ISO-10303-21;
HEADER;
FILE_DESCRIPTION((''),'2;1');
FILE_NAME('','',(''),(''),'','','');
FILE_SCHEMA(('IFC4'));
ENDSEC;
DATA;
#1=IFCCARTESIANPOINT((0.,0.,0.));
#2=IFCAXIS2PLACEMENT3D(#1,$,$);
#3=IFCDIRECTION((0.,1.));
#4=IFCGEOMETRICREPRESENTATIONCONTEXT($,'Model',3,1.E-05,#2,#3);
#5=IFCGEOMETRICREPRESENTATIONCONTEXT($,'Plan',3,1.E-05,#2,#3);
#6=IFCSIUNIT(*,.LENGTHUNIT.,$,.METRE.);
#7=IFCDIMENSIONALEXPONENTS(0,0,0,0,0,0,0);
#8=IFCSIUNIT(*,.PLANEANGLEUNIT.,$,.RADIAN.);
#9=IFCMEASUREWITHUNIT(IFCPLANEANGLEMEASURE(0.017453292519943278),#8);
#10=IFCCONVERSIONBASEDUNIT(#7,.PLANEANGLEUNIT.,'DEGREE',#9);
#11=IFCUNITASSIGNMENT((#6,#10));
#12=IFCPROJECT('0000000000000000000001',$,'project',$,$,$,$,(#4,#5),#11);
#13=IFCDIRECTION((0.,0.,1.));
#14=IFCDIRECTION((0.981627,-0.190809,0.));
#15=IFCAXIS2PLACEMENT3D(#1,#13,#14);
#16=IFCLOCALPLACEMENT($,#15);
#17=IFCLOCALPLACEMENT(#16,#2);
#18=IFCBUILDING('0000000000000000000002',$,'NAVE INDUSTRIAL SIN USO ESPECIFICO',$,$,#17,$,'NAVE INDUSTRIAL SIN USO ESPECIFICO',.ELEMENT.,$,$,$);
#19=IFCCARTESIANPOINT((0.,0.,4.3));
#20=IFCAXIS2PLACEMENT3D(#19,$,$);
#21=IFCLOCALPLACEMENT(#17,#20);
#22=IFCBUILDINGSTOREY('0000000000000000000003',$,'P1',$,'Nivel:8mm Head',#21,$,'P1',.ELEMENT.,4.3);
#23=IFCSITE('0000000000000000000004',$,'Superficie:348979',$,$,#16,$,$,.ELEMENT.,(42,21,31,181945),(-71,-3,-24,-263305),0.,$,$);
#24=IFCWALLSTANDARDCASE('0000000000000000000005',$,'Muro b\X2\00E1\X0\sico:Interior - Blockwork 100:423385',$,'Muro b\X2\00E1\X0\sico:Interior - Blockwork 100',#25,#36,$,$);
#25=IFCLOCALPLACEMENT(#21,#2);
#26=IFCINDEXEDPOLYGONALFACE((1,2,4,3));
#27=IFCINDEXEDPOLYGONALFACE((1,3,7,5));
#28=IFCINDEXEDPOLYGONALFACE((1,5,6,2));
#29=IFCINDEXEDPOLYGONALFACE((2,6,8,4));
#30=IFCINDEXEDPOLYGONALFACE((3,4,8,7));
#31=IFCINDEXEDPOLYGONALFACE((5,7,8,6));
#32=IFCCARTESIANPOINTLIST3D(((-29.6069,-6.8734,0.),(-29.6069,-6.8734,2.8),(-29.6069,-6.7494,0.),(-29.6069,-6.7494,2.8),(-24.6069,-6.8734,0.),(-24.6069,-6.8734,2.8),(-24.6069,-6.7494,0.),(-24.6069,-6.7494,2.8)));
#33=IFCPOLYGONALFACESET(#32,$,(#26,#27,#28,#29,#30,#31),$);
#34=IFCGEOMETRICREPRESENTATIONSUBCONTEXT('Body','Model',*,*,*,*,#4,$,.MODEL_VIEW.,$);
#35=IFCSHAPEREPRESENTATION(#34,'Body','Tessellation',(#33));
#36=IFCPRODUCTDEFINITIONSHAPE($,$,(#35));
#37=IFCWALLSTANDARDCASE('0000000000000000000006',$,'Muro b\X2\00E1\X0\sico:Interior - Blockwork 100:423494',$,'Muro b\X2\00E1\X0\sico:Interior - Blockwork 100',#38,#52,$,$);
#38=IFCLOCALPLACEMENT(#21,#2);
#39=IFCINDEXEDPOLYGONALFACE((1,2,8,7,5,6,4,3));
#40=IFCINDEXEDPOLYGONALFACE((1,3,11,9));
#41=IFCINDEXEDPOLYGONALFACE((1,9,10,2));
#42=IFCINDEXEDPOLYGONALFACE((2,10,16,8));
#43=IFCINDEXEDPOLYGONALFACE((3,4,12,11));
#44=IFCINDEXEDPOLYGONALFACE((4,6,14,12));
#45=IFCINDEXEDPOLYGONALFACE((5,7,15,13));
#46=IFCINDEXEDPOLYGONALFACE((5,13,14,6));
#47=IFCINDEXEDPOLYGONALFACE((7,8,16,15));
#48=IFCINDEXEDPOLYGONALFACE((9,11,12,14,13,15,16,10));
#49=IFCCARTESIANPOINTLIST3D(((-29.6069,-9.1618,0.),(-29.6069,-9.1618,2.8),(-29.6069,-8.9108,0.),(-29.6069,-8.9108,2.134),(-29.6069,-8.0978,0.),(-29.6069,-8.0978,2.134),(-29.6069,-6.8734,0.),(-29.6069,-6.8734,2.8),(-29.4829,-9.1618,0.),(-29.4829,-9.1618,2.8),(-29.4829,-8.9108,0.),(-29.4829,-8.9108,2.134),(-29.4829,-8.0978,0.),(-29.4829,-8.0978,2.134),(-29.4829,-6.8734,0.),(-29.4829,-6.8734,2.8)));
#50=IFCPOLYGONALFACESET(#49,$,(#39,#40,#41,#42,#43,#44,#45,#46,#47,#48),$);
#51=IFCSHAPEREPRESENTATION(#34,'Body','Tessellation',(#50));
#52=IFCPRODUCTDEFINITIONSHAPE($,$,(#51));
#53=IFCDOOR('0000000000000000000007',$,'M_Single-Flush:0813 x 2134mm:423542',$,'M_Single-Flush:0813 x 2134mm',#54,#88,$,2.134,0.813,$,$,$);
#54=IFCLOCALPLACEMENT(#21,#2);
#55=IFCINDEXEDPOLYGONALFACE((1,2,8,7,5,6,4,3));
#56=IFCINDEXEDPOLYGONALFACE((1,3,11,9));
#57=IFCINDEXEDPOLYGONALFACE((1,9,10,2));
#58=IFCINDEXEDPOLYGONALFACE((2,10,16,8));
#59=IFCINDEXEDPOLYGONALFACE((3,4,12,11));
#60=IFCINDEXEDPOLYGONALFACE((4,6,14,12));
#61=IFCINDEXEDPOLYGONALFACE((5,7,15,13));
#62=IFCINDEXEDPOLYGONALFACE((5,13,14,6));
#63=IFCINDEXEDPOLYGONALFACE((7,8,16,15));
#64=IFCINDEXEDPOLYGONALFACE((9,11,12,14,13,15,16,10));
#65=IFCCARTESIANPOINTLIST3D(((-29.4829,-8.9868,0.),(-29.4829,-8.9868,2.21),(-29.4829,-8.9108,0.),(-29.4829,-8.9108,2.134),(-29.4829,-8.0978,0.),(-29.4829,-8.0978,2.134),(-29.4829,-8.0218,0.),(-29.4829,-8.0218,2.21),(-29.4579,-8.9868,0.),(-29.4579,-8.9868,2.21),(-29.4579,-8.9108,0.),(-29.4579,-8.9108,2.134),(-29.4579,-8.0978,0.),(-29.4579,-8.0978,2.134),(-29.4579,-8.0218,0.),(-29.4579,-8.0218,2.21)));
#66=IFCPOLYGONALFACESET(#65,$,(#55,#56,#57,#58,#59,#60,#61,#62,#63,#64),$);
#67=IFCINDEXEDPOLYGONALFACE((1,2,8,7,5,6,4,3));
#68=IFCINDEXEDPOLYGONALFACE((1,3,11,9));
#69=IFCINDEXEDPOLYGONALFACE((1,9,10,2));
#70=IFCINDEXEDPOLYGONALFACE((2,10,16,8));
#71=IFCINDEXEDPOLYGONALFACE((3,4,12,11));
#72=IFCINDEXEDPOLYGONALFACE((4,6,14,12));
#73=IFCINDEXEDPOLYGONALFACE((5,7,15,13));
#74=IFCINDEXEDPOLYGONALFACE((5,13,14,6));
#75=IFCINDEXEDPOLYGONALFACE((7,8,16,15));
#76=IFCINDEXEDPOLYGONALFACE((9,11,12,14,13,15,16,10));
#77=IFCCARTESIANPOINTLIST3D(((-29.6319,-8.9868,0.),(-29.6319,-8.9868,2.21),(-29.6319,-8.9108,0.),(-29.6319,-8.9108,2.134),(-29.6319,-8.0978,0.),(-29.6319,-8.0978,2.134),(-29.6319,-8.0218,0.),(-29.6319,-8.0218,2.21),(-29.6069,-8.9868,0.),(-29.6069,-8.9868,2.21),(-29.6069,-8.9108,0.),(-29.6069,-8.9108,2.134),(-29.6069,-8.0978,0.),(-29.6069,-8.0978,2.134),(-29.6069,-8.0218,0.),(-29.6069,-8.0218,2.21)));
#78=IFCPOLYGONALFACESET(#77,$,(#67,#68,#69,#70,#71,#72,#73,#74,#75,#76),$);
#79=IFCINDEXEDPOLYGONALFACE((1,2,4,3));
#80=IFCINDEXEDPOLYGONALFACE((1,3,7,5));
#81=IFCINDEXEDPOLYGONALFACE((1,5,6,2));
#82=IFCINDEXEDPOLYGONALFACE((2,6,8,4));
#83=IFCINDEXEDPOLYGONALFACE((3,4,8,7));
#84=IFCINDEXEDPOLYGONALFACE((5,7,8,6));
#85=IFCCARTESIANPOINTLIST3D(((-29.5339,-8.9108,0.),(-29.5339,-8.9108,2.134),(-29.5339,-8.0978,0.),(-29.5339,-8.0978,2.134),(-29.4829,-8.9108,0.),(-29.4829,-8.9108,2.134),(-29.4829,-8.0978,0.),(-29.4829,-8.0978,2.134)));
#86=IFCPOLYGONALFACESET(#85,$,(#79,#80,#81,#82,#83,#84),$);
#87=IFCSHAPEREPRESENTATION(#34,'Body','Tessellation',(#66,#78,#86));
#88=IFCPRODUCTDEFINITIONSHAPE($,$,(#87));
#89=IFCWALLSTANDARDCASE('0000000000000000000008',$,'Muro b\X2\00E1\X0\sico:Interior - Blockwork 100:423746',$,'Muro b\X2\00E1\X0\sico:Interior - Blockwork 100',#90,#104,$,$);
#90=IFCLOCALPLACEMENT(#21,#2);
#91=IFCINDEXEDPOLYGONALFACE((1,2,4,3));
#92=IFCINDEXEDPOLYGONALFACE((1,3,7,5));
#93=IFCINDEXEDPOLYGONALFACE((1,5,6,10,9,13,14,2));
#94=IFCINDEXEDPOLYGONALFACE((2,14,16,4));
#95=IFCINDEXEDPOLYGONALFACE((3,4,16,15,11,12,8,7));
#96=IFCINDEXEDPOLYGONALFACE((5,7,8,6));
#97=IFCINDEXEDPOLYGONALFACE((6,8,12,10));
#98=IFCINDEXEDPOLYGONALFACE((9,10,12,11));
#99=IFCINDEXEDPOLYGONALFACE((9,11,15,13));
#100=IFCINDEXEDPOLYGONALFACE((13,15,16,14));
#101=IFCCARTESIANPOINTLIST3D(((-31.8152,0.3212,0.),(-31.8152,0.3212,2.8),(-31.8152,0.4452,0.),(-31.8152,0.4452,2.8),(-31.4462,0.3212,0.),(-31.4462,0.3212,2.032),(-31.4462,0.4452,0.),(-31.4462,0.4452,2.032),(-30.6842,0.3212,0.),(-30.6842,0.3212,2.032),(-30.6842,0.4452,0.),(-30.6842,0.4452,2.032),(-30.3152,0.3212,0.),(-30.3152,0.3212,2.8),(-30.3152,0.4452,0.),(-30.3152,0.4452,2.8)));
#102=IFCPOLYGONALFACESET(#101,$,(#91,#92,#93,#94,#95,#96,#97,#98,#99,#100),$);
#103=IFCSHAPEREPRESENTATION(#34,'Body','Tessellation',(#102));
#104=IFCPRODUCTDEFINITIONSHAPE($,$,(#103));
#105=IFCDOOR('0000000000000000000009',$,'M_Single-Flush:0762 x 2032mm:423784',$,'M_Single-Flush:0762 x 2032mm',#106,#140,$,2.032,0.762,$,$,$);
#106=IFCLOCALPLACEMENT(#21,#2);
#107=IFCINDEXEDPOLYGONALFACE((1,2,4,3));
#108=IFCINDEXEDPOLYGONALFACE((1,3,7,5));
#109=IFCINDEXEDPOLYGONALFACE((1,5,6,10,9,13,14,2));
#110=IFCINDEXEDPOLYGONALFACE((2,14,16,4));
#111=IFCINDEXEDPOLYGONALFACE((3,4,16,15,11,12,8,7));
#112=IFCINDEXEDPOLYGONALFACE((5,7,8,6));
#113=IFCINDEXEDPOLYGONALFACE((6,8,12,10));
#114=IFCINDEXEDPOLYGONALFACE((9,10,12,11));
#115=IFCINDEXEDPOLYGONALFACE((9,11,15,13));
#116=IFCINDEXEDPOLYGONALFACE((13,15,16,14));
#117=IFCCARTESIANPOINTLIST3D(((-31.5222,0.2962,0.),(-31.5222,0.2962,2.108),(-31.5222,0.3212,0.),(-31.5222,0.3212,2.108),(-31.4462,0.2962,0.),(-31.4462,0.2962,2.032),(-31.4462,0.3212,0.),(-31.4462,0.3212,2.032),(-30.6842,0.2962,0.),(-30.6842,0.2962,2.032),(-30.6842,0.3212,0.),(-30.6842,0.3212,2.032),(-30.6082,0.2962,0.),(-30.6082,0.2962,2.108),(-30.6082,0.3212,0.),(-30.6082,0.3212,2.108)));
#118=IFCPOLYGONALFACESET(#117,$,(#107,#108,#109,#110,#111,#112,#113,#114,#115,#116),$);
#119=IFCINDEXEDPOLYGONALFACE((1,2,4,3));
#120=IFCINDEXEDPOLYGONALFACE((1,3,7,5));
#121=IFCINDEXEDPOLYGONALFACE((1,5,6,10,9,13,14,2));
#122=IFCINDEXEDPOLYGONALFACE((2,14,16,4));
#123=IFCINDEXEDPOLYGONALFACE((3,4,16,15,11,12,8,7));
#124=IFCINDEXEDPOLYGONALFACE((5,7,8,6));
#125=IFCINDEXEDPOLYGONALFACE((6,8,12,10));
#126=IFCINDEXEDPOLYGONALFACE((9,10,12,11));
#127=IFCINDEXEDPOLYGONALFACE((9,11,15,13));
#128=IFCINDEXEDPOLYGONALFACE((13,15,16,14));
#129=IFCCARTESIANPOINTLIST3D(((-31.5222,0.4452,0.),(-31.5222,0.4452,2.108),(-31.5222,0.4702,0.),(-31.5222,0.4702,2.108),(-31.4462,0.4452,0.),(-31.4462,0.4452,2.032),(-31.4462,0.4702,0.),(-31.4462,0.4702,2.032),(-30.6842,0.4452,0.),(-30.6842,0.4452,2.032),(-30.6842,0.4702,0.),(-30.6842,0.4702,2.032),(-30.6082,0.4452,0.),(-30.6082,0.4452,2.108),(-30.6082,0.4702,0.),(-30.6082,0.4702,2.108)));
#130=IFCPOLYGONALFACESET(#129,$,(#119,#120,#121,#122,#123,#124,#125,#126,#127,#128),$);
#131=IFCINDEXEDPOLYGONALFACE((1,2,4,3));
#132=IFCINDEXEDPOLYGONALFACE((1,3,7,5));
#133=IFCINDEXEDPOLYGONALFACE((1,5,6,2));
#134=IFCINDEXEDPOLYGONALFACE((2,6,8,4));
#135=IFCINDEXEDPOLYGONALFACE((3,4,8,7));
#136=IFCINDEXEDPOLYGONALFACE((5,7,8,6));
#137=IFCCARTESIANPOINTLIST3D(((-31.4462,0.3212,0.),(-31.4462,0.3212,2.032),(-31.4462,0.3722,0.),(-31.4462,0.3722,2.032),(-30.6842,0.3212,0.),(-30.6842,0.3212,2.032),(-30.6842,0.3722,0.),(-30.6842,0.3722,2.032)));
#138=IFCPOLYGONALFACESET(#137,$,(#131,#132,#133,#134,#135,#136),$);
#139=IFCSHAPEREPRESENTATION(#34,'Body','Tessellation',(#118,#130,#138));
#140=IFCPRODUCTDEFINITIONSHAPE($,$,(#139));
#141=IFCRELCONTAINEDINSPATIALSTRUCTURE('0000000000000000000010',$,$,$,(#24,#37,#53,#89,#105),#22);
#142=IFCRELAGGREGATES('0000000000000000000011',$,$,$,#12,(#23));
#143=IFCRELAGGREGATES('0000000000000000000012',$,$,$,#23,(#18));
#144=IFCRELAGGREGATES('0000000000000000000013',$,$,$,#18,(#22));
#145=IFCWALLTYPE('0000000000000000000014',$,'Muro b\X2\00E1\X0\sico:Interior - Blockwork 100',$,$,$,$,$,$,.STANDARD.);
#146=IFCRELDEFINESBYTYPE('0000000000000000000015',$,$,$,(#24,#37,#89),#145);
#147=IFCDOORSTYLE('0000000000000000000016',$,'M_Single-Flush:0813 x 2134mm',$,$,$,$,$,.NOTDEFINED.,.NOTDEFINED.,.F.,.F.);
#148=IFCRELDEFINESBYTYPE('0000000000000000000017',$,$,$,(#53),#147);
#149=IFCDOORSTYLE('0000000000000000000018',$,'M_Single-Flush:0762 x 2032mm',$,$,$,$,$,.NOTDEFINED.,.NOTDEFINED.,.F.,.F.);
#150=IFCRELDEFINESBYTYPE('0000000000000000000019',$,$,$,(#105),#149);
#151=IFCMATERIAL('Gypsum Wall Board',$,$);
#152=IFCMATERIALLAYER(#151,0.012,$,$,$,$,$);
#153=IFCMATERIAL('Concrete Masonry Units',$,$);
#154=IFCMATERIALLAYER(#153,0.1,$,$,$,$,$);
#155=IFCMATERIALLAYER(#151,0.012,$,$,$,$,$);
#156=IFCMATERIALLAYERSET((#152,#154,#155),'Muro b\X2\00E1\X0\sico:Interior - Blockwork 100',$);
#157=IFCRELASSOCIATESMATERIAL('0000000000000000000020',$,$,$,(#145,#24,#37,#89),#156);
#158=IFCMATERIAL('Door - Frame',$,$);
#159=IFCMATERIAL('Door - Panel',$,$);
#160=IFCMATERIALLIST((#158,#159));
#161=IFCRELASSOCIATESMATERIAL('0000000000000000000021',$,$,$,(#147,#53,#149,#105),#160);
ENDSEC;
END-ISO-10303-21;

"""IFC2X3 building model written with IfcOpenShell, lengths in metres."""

from ifc_helpers import new_model, entity, si_unit, converted_unit, direction, frame, frame_2d, origin, origin_2d_with_axis, place, context, subcontext, project, spatial, polyline, rectangle, outline, extrude, source, transform, mapped, material, material_list, layer, layer_set, layer_usage, type_object, type_shapes, element, fill, save


model = new_model("IFC2X3")

# Units and contexts
model_context = context("Model", 3, precision=1e-05, world=origin(), true_north=direction((0.0, 1.0)))
plan_context = context("Plan", 3, precision=1e-05, world=origin(), true_north=direction((0.0, 1.0)))
body_context = subcontext(model_context, "Body", "Model", "MODEL_VIEW")
ifc_project = project(units=[si_unit("LENGTHUNIT", "METRE"), converted_unit("PLANEANGLEUNIT", "DEGREE", entity("IfcPlaneAngleMeasure", 0.017453292519943278), si_unit("PLANEANGLEUNIT", "RADIAN"), dimensions=[0, 0, 0, 0, 0, 0, 0])], contexts=[model_context, plan_context])

# Site, building, storey
site_placement = place(None, frame((0.0, 0.0, 0.0), z_axis=(0.0, 0.0, 1.0), x_axis=(0.981627, -0.190809, 0.0)))
site = spatial("IfcSite", under=ifc_project, at=site_placement, Name="Superficie:348979", CompositionType="ELEMENT", RefLatitude=(42, 21, 31, 181945), RefLongitude=(-71, -3, -24, -263305), RefElevation=0.0)
building_placement = place(site_placement, origin())
building = spatial("IfcBuilding", under=site, at=building_placement, Name="NAVE INDUSTRIAL SIN USO ESPECIFICO", LongName="NAVE INDUSTRIAL SIN USO ESPECIFICO", CompositionType="ELEMENT")
storey_placement = place(building_placement, frame((0.0, 0.0, 4.3)))
storey = spatial("IfcBuildingStorey", under=building, at=storey_placement, Name="P1", ObjectType="Nivel:8mm Head", LongName="P1", CompositionType="ELEMENT", Elevation=4.3)

# Shared definitions
ifc_material_1 = material(Name="Door - Frame")
ifc_material_2 = material(Name="Door - Panel")
ifc_material_list = material_list([ifc_material_1, ifc_material_2])

# Wall
ifc_material_3 = material(Name="Gypsum Wall Board")
ifc_layer_1 = layer(ifc_material_3, 0.012)
ifc_material_4 = material(Name="Concrete Masonry Units")
ifc_layer_2 = layer(ifc_material_4, 0.1)
ifc_layer_3 = layer(ifc_material_3, 0.012)
ifc_layer_set_1 = layer_set([ifc_layer_1, ifc_layer_2, ifc_layer_3], Name="Muro básico:Interior - Blockwork 100")
ifc_layer_usage_1 = layer_usage(ifc_layer_set_1, "AXIS2", "POSITIVE", -0.062)
wall_type_1 = type_object("IfcWallType", Name="Muro básico:Interior - Blockwork 100", PredefinedType="STANDARD", material=ifc_layer_set_1)
wall_1_placement = place(storey_placement, frame((-24.6069, -6.8114, 0.0), z_axis=(0.0, 0.0, 1.0), x_axis=(-1.0, 0.0, 0.0)))
element("IfcWallStandardCase", 1, at=wall_1_placement, inside=storey, type_object=wall_type_1, material=ifc_layer_usage_1, Name="Muro básico:Interior - Blockwork 100:423385", ObjectType="Muro básico:Interior - Blockwork 100", context=body_context, shape_type="SweptSolid", body=[
    extrude(rectangle(XDim=5.0, YDim=0.124, at=frame_2d((2.5, 0.0), x_axis=(-1.0, 0.0))), origin(), (0.0, 0.0, 1.0), 2.8),
])

# Walls, openings, doors
ifc_layer_usage_2 = layer_usage(ifc_layer_set_1, "AXIS2", "POSITIVE", -0.062)
wall_2_placement = place(storey_placement, frame((-29.5449, -6.8734, 0.0), z_axis=(0.0, 0.0, 1.0), x_axis=(0.0, -1.0, 0.0)))
wall_2 = element("IfcWallStandardCase", 2, at=wall_2_placement, inside=storey, type_object=wall_type_1, material=ifc_layer_usage_2, Name="Muro básico:Interior - Blockwork 100:423494", ObjectType="Muro básico:Interior - Blockwork 100", context=body_context, shape_type="SweptSolid", body=[
    extrude(rectangle(XDim=2.2884, YDim=0.124, at=frame_2d((1.1442, 0.0), x_axis=(1.0, 0.0))), origin(), (0.0, 0.0, 1.0), 2.8),
])
opening_1_placement = place(wall_2_placement, frame((1.2244, -0.062, 0.0)))
opening_1 = element("IfcOpeningElement", 3, at=opening_1_placement, cuts=wall_2, ObjectType="Opening", context=body_context, shape_type="SweptSolid", body=[
    extrude(rectangle(XDim=0.813, YDim=2.134, at=frame_2d((1.067, 0.4065), x_axis=(0.0, 1.0))), frame((0.0, 0.0, 0.0), z_axis=(0.0, 1.0, 0.0), x_axis=(0.0, 0.0, 1.0)), (0.0, 0.0, 1.0), 0.124),
])
door_style_1 = type_object("IfcDoorStyle", Name="M_Single-Flush:0813 x 2134mm", ConstructionType="NOTDEFINED", OperationType="NOTDEFINED", ParameterTakesPrecedence=False, Sizeable=False, material=ifc_material_list)
shared_shape_1 = source(origin(), body_context, "Body", "SweptSolid", [
    extrude(outline(polyline([(-0.4825, -1.124), (0.4825, -1.124), (0.4825, 1.086), (0.4065, 1.086), (0.4065, -1.048), (-0.4065, -1.048), (-0.4065, 1.086), (-0.4825, 1.086), (-0.4825, -1.124)])), frame((0.4065, 0.124, 1.086), z_axis=(0.0, 1.0, 0.0), x_axis=(1.0, 0.0, 0.0)), (0.0, 0.0, 1.0), 0.025),
    extrude(outline(polyline([(-1.124, -0.4825), (1.086, -0.4825), (1.086, -0.4065), (-1.048, -0.4065), (-1.048, 0.4065), (1.086, 0.4065), (1.086, 0.4825), (-1.124, 0.4825), (-1.124, -0.4825)])), frame((0.4065, -0.025, 1.086), z_axis=(0.0, 1.0, 0.0), x_axis=(0.0, 0.0, -1.0)), (0.0, 0.0, 1.0), 0.025),
    extrude(rectangle(XDim=0.051, YDim=0.813, at=origin_2d_with_axis()), frame((0.4065, 0.0985, 0.0), z_axis=(0.0, 0.0, 1.0), x_axis=(0.0, 1.0, 0.0)), (0.0, 0.0, 1.0), 2.134),
])
type_shapes(door_style_1, [shared_shape_1])
door_1_placement = place(opening_1_placement, origin())
door_1 = element("IfcDoor", 4, at=door_1_placement, inside=storey, type_object=door_style_1, material=ifc_material_list, Name="M_Single-Flush:0813 x 2134mm:423542", ObjectType="M_Single-Flush:0813 x 2134mm", OverallHeight=2.134, OverallWidth=0.813, context=body_context, shape_type="MappedRepresentation", body=[
    mapped(shared_shape_1, transform((0.0, 0.0, 0.0), scale=1.0)),
])
fill(opening_1, door_1)
ifc_layer_usage_3 = layer_usage(ifc_layer_set_1, "AXIS2", "NEGATIVE", 0.062)
wall_3_placement = place(storey_placement, frame((-31.8152, 0.3832, 0.0)))
wall_3 = element("IfcWallStandardCase", 5, at=wall_3_placement, inside=storey, type_object=wall_type_1, material=ifc_layer_usage_3, Name="Muro básico:Interior - Blockwork 100:423746", ObjectType="Muro básico:Interior - Blockwork 100", context=body_context, shape_type="SweptSolid", body=[
    extrude(rectangle(XDim=1.5, YDim=0.124, at=frame_2d((0.75, 0.0), x_axis=(-1.0, 0.0))), origin(), (0.0, 0.0, 1.0), 2.8),
])
opening_2_placement = place(wall_3_placement, frame((1.131, 0.062, 0.0)))
opening_2 = element("IfcOpeningElement", 6, at=opening_2_placement, cuts=wall_3, ObjectType="Opening", context=body_context, shape_type="SweptSolid", body=[
    extrude(rectangle(XDim=0.762, YDim=2.032, at=frame_2d((1.016, 0.381), x_axis=(0.0, 1.0))), frame((0.0, 0.0, 0.0), z_axis=(0.0, -1.0, 0.0), x_axis=(0.0, 0.0, 1.0)), (0.0, 0.0, 1.0), 0.124),
])
door_style_2 = type_object("IfcDoorStyle", Name="M_Single-Flush:0762 x 2032mm", ConstructionType="NOTDEFINED", OperationType="NOTDEFINED", ParameterTakesPrecedence=False, Sizeable=False, material=ifc_material_list)
shared_shape_2 = source(origin(), body_context, "Body", "SweptSolid", [
    extrude(outline(polyline([(-0.457, -1.073), (0.457, -1.073), (0.457, 1.035), (0.381, 1.035), (0.381, -0.997), (-0.381, -0.997), (-0.381, 1.035), (-0.457, 1.035), (-0.457, -1.073)])), frame((0.381, 0.124, 1.035), z_axis=(0.0, 1.0, 0.0), x_axis=(1.0, 0.0, 0.0)), (0.0, 0.0, 1.0), 0.025),
    extrude(outline(polyline([(-1.073, -0.457), (1.035, -0.457), (1.035, -0.381), (-0.997, -0.381), (-0.997, 0.381), (1.035, 0.381), (1.035, 0.457), (-1.073, 0.457), (-1.073, -0.457)])), frame((0.381, -0.025, 1.035), z_axis=(0.0, 1.0, 0.0), x_axis=(0.0, 0.0, -1.0)), (0.0, 0.0, 1.0), 0.025),
    extrude(rectangle(XDim=0.051, YDim=0.762, at=origin_2d_with_axis()), frame((0.381, 0.0985, 0.0), z_axis=(0.0, 0.0, 1.0), x_axis=(0.0, 1.0, 0.0)), (0.0, 0.0, 1.0), 2.032),
])
type_shapes(door_style_2, [shared_shape_2])
door_2_placement = place(opening_2_placement, frame((0.0, 0.0, 0.0), z_axis=(0.0, 0.0, 1.0), x_axis=(-1.0, 0.0, 0.0)))
door_2 = element("IfcDoor", 7, at=door_2_placement, inside=storey, type_object=door_style_2, material=ifc_material_list, Name="M_Single-Flush:0762 x 2032mm:423784", ObjectType="M_Single-Flush:0762 x 2032mm", OverallHeight=2.032, OverallWidth=0.762, context=body_context, shape_type="MappedRepresentation", body=[
    mapped(shared_shape_2, transform((0.0, 0.0, 0.0), scale=1.0)),
])
fill(opening_2, door_2)

save(model, "model.ifc")
